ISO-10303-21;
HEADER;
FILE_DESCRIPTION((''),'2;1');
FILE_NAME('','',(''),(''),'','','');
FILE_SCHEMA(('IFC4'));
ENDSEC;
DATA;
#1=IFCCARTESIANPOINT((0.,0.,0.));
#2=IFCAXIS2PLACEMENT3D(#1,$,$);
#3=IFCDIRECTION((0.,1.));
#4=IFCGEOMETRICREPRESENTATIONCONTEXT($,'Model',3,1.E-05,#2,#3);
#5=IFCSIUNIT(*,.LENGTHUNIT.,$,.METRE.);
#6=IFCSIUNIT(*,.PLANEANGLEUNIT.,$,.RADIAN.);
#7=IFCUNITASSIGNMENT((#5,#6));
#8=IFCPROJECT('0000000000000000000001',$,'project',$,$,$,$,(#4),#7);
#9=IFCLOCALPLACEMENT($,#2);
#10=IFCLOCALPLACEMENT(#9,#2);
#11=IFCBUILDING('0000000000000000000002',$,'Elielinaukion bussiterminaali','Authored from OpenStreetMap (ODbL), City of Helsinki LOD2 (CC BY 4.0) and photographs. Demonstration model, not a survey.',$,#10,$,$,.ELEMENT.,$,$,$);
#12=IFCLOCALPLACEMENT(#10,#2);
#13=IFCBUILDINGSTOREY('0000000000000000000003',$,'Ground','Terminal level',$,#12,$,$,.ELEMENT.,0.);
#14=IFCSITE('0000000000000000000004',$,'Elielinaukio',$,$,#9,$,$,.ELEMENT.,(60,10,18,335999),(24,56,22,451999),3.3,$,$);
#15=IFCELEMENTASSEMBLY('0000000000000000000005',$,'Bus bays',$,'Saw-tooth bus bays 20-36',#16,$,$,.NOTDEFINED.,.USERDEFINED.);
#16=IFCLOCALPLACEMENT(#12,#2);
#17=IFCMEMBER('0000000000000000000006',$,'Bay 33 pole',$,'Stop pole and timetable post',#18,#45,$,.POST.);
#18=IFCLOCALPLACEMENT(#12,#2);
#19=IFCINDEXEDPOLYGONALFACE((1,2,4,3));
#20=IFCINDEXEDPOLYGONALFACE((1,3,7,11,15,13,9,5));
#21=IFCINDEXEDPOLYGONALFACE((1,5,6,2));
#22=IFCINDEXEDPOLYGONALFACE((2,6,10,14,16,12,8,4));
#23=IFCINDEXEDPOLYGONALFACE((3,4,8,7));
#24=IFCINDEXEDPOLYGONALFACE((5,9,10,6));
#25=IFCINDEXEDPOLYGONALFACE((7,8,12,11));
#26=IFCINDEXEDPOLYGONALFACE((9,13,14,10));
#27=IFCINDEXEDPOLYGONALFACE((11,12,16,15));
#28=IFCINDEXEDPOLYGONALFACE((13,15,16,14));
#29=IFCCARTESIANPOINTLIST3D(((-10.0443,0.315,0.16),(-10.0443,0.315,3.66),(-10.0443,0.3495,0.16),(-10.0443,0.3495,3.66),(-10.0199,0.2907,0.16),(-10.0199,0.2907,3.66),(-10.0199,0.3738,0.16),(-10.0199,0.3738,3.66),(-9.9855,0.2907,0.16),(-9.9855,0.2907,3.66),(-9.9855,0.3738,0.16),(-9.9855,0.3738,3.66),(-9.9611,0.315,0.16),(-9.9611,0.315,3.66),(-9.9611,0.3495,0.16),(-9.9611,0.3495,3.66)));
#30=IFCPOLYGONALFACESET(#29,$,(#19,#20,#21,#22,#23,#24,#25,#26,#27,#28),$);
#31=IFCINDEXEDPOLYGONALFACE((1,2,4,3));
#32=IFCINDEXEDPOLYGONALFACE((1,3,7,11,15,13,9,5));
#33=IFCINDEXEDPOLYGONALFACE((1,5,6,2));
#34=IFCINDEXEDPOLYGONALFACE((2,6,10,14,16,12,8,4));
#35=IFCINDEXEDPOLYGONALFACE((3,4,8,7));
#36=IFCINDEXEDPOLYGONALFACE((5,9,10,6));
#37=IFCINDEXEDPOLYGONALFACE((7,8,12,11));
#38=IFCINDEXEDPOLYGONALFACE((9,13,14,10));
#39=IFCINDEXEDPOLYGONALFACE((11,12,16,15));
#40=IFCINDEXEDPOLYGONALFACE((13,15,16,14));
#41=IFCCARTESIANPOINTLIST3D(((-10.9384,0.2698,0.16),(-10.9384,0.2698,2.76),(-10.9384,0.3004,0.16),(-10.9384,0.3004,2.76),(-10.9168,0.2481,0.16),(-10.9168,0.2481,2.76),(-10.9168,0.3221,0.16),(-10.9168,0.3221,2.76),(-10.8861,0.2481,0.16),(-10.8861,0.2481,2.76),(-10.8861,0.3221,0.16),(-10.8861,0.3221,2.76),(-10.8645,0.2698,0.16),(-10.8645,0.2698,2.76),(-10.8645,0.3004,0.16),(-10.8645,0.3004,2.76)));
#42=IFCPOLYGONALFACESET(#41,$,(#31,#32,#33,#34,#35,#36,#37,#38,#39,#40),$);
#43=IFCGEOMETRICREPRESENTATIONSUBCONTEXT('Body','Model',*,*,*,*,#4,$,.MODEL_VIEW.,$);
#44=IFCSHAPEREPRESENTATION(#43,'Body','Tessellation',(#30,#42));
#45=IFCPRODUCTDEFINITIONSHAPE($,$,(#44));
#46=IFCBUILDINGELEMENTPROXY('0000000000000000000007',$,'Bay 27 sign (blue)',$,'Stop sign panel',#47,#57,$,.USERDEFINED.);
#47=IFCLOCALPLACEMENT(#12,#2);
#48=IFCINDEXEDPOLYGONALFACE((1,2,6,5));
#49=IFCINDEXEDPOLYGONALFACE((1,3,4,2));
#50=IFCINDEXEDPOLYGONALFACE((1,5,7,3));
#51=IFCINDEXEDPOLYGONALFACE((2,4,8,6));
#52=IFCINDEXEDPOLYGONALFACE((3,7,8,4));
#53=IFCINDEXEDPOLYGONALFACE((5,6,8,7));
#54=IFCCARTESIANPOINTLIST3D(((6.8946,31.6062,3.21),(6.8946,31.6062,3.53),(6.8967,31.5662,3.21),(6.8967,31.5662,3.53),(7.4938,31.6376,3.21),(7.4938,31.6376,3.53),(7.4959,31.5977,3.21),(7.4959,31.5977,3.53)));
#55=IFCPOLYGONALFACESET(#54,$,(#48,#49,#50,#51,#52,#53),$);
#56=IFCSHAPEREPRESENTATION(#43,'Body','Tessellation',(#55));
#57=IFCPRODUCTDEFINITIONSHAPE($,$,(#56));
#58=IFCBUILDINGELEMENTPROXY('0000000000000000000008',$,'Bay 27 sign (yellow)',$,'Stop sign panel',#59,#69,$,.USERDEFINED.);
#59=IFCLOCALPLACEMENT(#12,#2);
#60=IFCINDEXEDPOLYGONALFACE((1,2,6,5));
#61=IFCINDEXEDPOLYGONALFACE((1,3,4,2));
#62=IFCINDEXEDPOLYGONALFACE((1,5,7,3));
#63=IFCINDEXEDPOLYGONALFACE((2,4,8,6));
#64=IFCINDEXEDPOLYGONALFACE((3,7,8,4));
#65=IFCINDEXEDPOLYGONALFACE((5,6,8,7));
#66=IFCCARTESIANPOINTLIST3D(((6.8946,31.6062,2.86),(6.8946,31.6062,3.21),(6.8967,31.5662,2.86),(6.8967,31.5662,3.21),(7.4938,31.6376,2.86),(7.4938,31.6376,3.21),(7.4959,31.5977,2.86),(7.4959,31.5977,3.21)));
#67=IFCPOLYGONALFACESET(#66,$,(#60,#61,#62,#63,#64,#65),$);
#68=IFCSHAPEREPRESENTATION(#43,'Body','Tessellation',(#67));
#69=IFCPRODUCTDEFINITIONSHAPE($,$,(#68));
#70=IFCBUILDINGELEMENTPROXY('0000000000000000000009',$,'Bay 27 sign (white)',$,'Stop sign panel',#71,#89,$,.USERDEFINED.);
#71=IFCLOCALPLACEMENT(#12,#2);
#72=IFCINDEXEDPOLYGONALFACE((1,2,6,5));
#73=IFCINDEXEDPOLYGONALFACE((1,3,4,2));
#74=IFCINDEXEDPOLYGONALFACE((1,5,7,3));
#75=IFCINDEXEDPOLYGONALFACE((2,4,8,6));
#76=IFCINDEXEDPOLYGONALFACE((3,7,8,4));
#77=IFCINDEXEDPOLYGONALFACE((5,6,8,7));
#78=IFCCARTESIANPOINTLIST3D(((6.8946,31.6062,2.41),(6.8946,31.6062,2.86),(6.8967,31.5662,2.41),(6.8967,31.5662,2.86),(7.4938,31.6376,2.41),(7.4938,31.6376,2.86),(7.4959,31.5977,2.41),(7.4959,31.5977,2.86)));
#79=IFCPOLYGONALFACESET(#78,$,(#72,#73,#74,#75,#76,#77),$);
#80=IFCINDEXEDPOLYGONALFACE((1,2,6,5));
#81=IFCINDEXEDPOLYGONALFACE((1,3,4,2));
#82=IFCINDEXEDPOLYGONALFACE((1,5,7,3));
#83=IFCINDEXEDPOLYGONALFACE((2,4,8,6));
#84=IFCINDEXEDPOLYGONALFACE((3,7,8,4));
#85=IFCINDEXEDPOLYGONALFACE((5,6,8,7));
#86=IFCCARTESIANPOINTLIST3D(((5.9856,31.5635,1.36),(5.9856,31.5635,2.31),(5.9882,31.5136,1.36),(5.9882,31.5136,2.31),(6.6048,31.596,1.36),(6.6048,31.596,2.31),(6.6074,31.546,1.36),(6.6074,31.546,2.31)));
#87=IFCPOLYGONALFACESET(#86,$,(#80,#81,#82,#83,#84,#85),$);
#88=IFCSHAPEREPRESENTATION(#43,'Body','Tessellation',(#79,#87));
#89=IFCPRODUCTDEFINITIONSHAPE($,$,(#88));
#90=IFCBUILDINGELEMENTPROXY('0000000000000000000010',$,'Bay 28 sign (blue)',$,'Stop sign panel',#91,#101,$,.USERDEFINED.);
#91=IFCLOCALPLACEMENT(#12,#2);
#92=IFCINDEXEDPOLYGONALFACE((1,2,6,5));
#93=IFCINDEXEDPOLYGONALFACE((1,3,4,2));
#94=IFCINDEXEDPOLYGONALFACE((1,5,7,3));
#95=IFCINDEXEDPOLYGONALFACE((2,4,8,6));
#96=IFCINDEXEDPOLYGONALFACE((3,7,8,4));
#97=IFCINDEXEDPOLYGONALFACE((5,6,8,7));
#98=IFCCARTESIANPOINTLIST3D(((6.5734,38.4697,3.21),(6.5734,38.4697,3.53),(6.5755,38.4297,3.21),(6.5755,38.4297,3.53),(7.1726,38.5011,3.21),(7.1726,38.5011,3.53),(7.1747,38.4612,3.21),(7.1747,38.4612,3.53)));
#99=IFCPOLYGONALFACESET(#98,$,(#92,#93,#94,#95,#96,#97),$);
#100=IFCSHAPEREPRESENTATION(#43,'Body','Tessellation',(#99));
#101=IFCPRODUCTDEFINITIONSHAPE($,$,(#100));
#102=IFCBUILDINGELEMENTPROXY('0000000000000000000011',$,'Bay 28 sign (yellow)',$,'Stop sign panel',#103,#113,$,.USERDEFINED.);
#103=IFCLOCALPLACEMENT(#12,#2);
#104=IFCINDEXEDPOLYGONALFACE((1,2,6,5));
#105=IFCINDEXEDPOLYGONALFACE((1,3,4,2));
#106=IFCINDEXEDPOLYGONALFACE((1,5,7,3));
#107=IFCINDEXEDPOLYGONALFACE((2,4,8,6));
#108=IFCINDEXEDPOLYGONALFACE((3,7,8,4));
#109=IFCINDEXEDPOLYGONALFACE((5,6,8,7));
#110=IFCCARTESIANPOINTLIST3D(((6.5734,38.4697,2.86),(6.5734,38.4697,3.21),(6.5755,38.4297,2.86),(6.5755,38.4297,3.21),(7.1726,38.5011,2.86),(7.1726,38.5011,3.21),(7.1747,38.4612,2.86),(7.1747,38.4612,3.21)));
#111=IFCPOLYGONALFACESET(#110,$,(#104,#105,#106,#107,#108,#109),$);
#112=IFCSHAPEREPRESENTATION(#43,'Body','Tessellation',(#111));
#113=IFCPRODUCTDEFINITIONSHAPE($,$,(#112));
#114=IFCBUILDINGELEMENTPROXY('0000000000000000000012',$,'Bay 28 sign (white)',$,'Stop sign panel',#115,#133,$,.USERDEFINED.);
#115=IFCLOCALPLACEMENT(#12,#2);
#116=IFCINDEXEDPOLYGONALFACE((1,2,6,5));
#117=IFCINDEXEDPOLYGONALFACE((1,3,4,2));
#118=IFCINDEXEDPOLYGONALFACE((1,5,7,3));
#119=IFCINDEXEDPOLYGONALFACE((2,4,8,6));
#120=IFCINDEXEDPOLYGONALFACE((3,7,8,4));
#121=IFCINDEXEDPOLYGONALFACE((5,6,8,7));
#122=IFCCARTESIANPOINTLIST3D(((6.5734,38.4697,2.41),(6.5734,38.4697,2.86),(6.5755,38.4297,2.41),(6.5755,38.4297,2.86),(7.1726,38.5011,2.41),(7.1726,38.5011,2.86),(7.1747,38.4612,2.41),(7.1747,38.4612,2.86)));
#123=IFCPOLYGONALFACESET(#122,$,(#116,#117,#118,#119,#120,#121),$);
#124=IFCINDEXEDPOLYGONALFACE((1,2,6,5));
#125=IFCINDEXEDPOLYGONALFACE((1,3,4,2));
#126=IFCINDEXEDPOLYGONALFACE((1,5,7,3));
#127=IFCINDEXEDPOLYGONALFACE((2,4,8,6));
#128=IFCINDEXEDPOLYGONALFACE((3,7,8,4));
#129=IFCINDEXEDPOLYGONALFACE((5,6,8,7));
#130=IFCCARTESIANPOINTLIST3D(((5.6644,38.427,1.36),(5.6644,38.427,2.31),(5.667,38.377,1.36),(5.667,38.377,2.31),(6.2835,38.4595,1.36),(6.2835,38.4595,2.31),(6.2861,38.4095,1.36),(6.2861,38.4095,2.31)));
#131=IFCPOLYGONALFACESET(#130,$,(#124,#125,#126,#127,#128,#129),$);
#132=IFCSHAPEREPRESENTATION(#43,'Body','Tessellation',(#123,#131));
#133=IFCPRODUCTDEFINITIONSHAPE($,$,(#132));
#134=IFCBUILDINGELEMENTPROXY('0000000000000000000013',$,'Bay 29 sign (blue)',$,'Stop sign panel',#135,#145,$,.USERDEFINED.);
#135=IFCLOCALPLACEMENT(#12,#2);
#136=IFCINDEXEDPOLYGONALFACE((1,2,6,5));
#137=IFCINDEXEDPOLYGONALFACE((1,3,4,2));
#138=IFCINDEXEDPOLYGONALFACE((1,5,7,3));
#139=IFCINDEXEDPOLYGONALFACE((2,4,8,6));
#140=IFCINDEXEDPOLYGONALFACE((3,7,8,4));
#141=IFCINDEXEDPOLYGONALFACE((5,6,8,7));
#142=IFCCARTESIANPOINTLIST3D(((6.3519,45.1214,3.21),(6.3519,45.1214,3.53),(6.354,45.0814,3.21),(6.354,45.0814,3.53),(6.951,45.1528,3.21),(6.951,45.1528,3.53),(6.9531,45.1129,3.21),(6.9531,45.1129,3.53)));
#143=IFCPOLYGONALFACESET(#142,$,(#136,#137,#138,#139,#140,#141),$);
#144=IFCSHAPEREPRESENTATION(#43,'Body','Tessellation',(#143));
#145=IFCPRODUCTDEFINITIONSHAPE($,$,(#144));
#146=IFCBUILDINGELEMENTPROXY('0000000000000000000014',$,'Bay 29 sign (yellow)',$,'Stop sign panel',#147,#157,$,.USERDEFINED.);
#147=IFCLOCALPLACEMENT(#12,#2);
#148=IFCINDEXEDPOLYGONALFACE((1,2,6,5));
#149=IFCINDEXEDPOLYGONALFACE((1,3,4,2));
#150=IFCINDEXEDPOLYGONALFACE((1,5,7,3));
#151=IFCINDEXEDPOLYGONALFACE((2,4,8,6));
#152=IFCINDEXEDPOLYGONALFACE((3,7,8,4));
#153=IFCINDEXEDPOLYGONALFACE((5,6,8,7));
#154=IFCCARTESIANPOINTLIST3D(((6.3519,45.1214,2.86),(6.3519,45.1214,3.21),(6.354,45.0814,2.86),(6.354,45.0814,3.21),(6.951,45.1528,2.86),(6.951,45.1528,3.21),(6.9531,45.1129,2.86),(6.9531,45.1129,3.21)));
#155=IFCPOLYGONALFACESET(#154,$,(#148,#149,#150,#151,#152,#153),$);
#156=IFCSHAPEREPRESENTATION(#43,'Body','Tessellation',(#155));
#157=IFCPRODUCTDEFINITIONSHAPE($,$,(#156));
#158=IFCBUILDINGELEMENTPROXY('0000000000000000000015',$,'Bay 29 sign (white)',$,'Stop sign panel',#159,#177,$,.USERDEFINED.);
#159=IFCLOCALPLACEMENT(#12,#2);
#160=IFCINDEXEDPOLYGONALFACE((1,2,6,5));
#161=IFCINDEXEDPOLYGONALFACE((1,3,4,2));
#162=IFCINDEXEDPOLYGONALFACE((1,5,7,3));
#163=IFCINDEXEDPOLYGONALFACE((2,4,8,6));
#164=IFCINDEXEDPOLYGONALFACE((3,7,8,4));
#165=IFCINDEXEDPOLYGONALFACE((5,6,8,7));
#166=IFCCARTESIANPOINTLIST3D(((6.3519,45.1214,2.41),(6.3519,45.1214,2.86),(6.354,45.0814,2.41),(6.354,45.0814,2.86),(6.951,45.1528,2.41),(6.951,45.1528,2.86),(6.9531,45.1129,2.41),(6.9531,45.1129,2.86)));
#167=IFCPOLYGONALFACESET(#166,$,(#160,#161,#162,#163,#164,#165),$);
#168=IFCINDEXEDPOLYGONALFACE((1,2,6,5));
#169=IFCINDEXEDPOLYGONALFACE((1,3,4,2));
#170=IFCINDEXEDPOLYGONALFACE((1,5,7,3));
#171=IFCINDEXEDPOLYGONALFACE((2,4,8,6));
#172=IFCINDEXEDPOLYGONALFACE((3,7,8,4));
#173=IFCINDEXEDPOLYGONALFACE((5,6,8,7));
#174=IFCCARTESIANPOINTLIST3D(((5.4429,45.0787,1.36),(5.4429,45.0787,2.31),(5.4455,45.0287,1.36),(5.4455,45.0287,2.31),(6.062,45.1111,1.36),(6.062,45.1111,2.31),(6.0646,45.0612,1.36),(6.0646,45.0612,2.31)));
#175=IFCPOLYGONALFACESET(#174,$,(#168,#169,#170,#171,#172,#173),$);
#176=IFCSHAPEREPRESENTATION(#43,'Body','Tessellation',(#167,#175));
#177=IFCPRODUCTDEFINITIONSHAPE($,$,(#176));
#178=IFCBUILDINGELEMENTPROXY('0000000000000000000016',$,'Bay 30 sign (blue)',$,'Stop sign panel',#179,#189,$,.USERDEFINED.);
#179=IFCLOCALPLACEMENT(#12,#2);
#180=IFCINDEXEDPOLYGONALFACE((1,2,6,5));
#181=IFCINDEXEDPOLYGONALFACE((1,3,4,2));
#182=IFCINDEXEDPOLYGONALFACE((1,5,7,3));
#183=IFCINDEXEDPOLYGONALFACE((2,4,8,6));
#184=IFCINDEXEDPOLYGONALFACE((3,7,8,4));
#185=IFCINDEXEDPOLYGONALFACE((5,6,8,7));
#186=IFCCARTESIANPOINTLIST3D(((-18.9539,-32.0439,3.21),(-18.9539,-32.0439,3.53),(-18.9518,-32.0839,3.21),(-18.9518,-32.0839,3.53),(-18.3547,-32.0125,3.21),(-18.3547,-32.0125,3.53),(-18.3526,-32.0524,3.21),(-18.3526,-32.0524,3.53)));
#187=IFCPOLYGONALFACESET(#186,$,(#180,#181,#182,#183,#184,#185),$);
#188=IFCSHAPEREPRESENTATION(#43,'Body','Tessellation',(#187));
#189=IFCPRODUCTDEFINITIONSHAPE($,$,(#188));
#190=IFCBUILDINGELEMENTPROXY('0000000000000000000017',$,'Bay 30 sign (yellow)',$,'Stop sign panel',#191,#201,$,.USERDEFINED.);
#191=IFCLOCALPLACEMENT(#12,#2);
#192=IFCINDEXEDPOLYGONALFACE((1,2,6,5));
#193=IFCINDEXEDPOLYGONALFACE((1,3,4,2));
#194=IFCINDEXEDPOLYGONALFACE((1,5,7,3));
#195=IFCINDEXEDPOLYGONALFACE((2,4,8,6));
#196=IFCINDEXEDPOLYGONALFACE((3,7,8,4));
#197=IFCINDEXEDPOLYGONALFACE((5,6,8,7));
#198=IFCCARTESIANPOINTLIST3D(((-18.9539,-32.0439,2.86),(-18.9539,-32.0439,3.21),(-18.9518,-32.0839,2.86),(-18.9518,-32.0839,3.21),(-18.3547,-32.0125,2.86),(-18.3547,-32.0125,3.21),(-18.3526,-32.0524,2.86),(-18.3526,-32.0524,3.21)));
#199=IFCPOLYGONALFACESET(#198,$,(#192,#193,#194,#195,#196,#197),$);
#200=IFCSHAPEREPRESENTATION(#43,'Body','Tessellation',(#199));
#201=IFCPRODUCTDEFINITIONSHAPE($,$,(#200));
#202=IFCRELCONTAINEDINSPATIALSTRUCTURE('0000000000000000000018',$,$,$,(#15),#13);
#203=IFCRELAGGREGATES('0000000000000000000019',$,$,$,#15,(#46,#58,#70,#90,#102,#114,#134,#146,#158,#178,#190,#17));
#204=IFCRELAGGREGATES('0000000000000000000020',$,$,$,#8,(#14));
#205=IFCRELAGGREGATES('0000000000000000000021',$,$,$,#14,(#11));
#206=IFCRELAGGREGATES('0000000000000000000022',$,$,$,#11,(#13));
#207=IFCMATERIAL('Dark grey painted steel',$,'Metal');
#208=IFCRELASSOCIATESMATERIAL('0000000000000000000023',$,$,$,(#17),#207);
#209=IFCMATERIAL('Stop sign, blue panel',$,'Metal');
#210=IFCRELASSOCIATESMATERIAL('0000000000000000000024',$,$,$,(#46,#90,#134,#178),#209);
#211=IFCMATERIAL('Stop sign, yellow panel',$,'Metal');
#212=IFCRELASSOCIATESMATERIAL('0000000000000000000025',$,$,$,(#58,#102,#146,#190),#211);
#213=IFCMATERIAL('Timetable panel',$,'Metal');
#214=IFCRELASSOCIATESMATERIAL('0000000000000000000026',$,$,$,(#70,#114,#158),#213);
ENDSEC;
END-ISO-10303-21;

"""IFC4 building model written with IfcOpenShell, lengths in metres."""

from ifc_helpers import new_model, si_unit, direction, frame, frame_2d, origin, place, context, subcontext, project, spatial, polyline, rectangle, outline, extrude, material, element, aggregate, save


model = new_model("IFC4")

# Units and contexts
model_context = context("Model", 3, precision=1e-05, world=origin(), true_north=direction((0.0, 1.0)))
body_context = subcontext(model_context, "Body", "Model", "MODEL_VIEW")
ifc_project = project(units=[si_unit("LENGTHUNIT", "METRE"), si_unit("PLANEANGLEUNIT", "RADIAN")], contexts=[model_context])

# Site, building, storey
site_placement = place(None, origin())
site = spatial("IfcSite", under=ifc_project, at=site_placement, Name="Elielinaukio", CompositionType="ELEMENT", RefLatitude=(60, 10, 18, 335999), RefLongitude=(24, 56, 22, 451999), RefElevation=3.3)
building_placement = place(site_placement, origin())
building = spatial("IfcBuilding", under=site, at=building_placement, Name="Elielinaukion bussiterminaali", Description="Authored from OpenStreetMap (ODbL), City of Helsinki LOD2 (CC BY 4.0) and photographs. Demonstration model, not a survey.", CompositionType="ELEMENT")
storey_placement = place(building_placement, origin())
storey = spatial("IfcBuildingStorey", under=building, at=storey_placement, Name="Ground", Description="Terminal level", CompositionType="ELEMENT", Elevation=0.0)

# Element assembly, member, building element proxies
assembly_placement = place(building_placement, origin())
assembly = element("IfcElementAssembly", 1, at=assembly_placement, inside=storey, Name="Bus bays", ObjectType="Saw-tooth bus bays 20-36", AssemblyPlace="NOTDEFINED", PredefinedType="USERDEFINED")
ifc_material_1 = material(Name="Dark grey painted steel", Category="Metal")
member_1_placement = place(building_placement, origin())
member_1 = element("IfcMember", 2, at=member_1_placement, material=ifc_material_1, Name="Bay 33 pole", ObjectType="Stop pole and timetable post", PredefinedType="POST", context=body_context, shape_type="SweptSolid", body=[
    extrude(outline(polyline([(-9.9611, 0.3495), (-9.9855, 0.3738), (-10.0199, 0.3738), (-10.0443, 0.3495), (-10.0443, 0.315), (-10.0199, 0.2907), (-9.9855, 0.2907), (-9.9611, 0.315), (-9.9611, 0.3495)])), frame((0.0, 0.0, 0.16)), (0.0, 0.0, 1.0), 3.5),
    extrude(outline(polyline([(-10.8645, 0.3004), (-10.8861, 0.3221), (-10.9168, 0.3221), (-10.9384, 0.3004), (-10.9384, 0.2698), (-10.9168, 0.2481), (-10.8861, 0.2481), (-10.8645, 0.2698), (-10.8645, 0.3004)])), frame((0.0, 0.0, 0.16)), (0.0, 0.0, 1.0), 2.6),
])
ifc_material_2 = material(Name="Stop sign, blue panel", Category="Metal")
proxy_1_placement = place(building_placement, origin())
proxy_1 = element("IfcBuildingElementProxy", 3, at=proxy_1_placement, material=ifc_material_2, Name="Bay 27 sign (blue)", ObjectType="Stop sign panel", PredefinedType="USERDEFINED", context=body_context, shape_type="SweptSolid", body=[
    extrude(rectangle(XDim=0.04, YDim=0.6, at=frame_2d((0.0, 0.0), x_axis=(-0.052408, 0.998626))), frame((7.1953, 31.6019, 3.21)), (0.0, 0.0, 1.0), 0.32),
])
ifc_material_3 = material(Name="Stop sign, yellow panel", Category="Metal")
proxy_2_placement = place(building_placement, origin())
proxy_2 = element("IfcBuildingElementProxy", 4, at=proxy_2_placement, material=ifc_material_3, Name="Bay 27 sign (yellow)", ObjectType="Stop sign panel", PredefinedType="USERDEFINED", context=body_context, shape_type="SweptSolid", body=[
    extrude(rectangle(XDim=0.04, YDim=0.6, at=frame_2d((0.0, 0.0), x_axis=(-0.052408, 0.998626))), frame((7.1953, 31.6019, 2.86)), (0.0, 0.0, 1.0), 0.35),
])
ifc_material_4 = material(Name="Timetable panel", Category="Metal")
proxy_3_placement = place(building_placement, origin())
proxy_3 = element("IfcBuildingElementProxy", 5, at=proxy_3_placement, material=ifc_material_4, Name="Bay 27 sign (white)", ObjectType="Stop sign panel", PredefinedType="USERDEFINED", context=body_context, shape_type="SweptSolid", body=[
    extrude(rectangle(XDim=0.04, YDim=0.6, at=frame_2d((0.0, 0.0), x_axis=(-0.052408, 0.998626))), frame((7.1953, 31.6019, 2.41)), (0.0, 0.0, 1.0), 0.45),
    extrude(rectangle(XDim=0.05, YDim=0.62, at=frame_2d((0.0, 0.0), x_axis=(-0.052408, 0.998626))), frame((6.2965, 31.5548, 1.36)), (0.0, 0.0, 1.0), 0.95),
])
proxy_4_placement = place(building_placement, origin())
proxy_4 = element("IfcBuildingElementProxy", 6, at=proxy_4_placement, material=ifc_material_2, Name="Bay 28 sign (blue)", ObjectType="Stop sign panel", PredefinedType="USERDEFINED", context=body_context, shape_type="SweptSolid", body=[
    extrude(rectangle(XDim=0.04, YDim=0.6, at=frame_2d((0.0, 0.0), x_axis=(-0.052408, 0.998626))), frame((6.874, 38.4654, 3.21)), (0.0, 0.0, 1.0), 0.32),
])
proxy_5_placement = place(building_placement, origin())
proxy_5 = element("IfcBuildingElementProxy", 7, at=proxy_5_placement, material=ifc_material_3, Name="Bay 28 sign (yellow)", ObjectType="Stop sign panel", PredefinedType="USERDEFINED", context=body_context, shape_type="SweptSolid", body=[
    extrude(rectangle(XDim=0.04, YDim=0.6, at=frame_2d((0.0, 0.0), x_axis=(-0.052408, 0.998626))), frame((6.874, 38.4654, 2.86)), (0.0, 0.0, 1.0), 0.35),
])
proxy_6_placement = place(building_placement, origin())
proxy_6 = element("IfcBuildingElementProxy", 8, at=proxy_6_placement, material=ifc_material_4, Name="Bay 28 sign (white)", ObjectType="Stop sign panel", PredefinedType="USERDEFINED", context=body_context, shape_type="SweptSolid", body=[
    extrude(rectangle(XDim=0.04, YDim=0.6, at=frame_2d((0.0, 0.0), x_axis=(-0.052408, 0.998626))), frame((6.874, 38.4654, 2.41)), (0.0, 0.0, 1.0), 0.45),
    extrude(rectangle(XDim=0.05, YDim=0.62, at=frame_2d((0.0, 0.0), x_axis=(-0.052408, 0.998626))), frame((5.9753, 38.4182, 1.36)), (0.0, 0.0, 1.0), 0.95),
])
proxy_7_placement = place(building_placement, origin())
proxy_7 = element("IfcBuildingElementProxy", 9, at=proxy_7_placement, material=ifc_material_2, Name="Bay 29 sign (blue)", ObjectType="Stop sign panel", PredefinedType="USERDEFINED", context=body_context, shape_type="SweptSolid", body=[
    extrude(rectangle(XDim=0.04, YDim=0.6, at=frame_2d((0.0, 0.0), x_axis=(-0.052408, 0.998626))), frame((6.6525, 45.1171, 3.21)), (0.0, 0.0, 1.0), 0.32),
])
proxy_8_placement = place(building_placement, origin())
proxy_8 = element("IfcBuildingElementProxy", 10, at=proxy_8_placement, material=ifc_material_3, Name="Bay 29 sign (yellow)", ObjectType="Stop sign panel", PredefinedType="USERDEFINED", context=body_context, shape_type="SweptSolid", body=[
    extrude(rectangle(XDim=0.04, YDim=0.6, at=frame_2d((0.0, 0.0), x_axis=(-0.052408, 0.998626))), frame((6.6525, 45.1171, 2.86)), (0.0, 0.0, 1.0), 0.35),
])
proxy_9_placement = place(building_placement, origin())
proxy_9 = element("IfcBuildingElementProxy", 11, at=proxy_9_placement, material=ifc_material_4, Name="Bay 29 sign (white)", ObjectType="Stop sign panel", PredefinedType="USERDEFINED", context=body_context, shape_type="SweptSolid", body=[
    extrude(rectangle(XDim=0.04, YDim=0.6, at=frame_2d((0.0, 0.0), x_axis=(-0.052408, 0.998626))), frame((6.6525, 45.1171, 2.41)), (0.0, 0.0, 1.0), 0.45),
    extrude(rectangle(XDim=0.05, YDim=0.62, at=frame_2d((0.0, 0.0), x_axis=(-0.052408, 0.998626))), frame((5.7537, 45.0699, 1.36)), (0.0, 0.0, 1.0), 0.95),
])
proxy_10_placement = place(building_placement, origin())
proxy_10 = element("IfcBuildingElementProxy", 12, at=proxy_10_placement, material=ifc_material_2, Name="Bay 30 sign (blue)", ObjectType="Stop sign panel", PredefinedType="USERDEFINED", context=body_context, shape_type="SweptSolid", body=[
    extrude(rectangle(XDim=0.04, YDim=0.6, at=frame_2d((0.0, 0.0), x_axis=(-0.052408, 0.998626))), frame((-18.6533, -32.0482, 3.21)), (0.0, 0.0, 1.0), 0.32),
])
proxy_11_placement = place(building_placement, origin())
proxy_11 = element("IfcBuildingElementProxy", 13, at=proxy_11_placement, material=ifc_material_3, Name="Bay 30 sign (yellow)", ObjectType="Stop sign panel", PredefinedType="USERDEFINED", context=body_context, shape_type="SweptSolid", body=[
    extrude(rectangle(XDim=0.04, YDim=0.6, at=frame_2d((0.0, 0.0), x_axis=(-0.052408, 0.998626))), frame((-18.6533, -32.0482, 2.86)), (0.0, 0.0, 1.0), 0.35),
])
aggregate(assembly, [proxy_1, proxy_2, proxy_3, proxy_4, proxy_5, proxy_6, proxy_7, proxy_8, proxy_9, proxy_10, proxy_11, member_1])

save(model, "model.ifc")
